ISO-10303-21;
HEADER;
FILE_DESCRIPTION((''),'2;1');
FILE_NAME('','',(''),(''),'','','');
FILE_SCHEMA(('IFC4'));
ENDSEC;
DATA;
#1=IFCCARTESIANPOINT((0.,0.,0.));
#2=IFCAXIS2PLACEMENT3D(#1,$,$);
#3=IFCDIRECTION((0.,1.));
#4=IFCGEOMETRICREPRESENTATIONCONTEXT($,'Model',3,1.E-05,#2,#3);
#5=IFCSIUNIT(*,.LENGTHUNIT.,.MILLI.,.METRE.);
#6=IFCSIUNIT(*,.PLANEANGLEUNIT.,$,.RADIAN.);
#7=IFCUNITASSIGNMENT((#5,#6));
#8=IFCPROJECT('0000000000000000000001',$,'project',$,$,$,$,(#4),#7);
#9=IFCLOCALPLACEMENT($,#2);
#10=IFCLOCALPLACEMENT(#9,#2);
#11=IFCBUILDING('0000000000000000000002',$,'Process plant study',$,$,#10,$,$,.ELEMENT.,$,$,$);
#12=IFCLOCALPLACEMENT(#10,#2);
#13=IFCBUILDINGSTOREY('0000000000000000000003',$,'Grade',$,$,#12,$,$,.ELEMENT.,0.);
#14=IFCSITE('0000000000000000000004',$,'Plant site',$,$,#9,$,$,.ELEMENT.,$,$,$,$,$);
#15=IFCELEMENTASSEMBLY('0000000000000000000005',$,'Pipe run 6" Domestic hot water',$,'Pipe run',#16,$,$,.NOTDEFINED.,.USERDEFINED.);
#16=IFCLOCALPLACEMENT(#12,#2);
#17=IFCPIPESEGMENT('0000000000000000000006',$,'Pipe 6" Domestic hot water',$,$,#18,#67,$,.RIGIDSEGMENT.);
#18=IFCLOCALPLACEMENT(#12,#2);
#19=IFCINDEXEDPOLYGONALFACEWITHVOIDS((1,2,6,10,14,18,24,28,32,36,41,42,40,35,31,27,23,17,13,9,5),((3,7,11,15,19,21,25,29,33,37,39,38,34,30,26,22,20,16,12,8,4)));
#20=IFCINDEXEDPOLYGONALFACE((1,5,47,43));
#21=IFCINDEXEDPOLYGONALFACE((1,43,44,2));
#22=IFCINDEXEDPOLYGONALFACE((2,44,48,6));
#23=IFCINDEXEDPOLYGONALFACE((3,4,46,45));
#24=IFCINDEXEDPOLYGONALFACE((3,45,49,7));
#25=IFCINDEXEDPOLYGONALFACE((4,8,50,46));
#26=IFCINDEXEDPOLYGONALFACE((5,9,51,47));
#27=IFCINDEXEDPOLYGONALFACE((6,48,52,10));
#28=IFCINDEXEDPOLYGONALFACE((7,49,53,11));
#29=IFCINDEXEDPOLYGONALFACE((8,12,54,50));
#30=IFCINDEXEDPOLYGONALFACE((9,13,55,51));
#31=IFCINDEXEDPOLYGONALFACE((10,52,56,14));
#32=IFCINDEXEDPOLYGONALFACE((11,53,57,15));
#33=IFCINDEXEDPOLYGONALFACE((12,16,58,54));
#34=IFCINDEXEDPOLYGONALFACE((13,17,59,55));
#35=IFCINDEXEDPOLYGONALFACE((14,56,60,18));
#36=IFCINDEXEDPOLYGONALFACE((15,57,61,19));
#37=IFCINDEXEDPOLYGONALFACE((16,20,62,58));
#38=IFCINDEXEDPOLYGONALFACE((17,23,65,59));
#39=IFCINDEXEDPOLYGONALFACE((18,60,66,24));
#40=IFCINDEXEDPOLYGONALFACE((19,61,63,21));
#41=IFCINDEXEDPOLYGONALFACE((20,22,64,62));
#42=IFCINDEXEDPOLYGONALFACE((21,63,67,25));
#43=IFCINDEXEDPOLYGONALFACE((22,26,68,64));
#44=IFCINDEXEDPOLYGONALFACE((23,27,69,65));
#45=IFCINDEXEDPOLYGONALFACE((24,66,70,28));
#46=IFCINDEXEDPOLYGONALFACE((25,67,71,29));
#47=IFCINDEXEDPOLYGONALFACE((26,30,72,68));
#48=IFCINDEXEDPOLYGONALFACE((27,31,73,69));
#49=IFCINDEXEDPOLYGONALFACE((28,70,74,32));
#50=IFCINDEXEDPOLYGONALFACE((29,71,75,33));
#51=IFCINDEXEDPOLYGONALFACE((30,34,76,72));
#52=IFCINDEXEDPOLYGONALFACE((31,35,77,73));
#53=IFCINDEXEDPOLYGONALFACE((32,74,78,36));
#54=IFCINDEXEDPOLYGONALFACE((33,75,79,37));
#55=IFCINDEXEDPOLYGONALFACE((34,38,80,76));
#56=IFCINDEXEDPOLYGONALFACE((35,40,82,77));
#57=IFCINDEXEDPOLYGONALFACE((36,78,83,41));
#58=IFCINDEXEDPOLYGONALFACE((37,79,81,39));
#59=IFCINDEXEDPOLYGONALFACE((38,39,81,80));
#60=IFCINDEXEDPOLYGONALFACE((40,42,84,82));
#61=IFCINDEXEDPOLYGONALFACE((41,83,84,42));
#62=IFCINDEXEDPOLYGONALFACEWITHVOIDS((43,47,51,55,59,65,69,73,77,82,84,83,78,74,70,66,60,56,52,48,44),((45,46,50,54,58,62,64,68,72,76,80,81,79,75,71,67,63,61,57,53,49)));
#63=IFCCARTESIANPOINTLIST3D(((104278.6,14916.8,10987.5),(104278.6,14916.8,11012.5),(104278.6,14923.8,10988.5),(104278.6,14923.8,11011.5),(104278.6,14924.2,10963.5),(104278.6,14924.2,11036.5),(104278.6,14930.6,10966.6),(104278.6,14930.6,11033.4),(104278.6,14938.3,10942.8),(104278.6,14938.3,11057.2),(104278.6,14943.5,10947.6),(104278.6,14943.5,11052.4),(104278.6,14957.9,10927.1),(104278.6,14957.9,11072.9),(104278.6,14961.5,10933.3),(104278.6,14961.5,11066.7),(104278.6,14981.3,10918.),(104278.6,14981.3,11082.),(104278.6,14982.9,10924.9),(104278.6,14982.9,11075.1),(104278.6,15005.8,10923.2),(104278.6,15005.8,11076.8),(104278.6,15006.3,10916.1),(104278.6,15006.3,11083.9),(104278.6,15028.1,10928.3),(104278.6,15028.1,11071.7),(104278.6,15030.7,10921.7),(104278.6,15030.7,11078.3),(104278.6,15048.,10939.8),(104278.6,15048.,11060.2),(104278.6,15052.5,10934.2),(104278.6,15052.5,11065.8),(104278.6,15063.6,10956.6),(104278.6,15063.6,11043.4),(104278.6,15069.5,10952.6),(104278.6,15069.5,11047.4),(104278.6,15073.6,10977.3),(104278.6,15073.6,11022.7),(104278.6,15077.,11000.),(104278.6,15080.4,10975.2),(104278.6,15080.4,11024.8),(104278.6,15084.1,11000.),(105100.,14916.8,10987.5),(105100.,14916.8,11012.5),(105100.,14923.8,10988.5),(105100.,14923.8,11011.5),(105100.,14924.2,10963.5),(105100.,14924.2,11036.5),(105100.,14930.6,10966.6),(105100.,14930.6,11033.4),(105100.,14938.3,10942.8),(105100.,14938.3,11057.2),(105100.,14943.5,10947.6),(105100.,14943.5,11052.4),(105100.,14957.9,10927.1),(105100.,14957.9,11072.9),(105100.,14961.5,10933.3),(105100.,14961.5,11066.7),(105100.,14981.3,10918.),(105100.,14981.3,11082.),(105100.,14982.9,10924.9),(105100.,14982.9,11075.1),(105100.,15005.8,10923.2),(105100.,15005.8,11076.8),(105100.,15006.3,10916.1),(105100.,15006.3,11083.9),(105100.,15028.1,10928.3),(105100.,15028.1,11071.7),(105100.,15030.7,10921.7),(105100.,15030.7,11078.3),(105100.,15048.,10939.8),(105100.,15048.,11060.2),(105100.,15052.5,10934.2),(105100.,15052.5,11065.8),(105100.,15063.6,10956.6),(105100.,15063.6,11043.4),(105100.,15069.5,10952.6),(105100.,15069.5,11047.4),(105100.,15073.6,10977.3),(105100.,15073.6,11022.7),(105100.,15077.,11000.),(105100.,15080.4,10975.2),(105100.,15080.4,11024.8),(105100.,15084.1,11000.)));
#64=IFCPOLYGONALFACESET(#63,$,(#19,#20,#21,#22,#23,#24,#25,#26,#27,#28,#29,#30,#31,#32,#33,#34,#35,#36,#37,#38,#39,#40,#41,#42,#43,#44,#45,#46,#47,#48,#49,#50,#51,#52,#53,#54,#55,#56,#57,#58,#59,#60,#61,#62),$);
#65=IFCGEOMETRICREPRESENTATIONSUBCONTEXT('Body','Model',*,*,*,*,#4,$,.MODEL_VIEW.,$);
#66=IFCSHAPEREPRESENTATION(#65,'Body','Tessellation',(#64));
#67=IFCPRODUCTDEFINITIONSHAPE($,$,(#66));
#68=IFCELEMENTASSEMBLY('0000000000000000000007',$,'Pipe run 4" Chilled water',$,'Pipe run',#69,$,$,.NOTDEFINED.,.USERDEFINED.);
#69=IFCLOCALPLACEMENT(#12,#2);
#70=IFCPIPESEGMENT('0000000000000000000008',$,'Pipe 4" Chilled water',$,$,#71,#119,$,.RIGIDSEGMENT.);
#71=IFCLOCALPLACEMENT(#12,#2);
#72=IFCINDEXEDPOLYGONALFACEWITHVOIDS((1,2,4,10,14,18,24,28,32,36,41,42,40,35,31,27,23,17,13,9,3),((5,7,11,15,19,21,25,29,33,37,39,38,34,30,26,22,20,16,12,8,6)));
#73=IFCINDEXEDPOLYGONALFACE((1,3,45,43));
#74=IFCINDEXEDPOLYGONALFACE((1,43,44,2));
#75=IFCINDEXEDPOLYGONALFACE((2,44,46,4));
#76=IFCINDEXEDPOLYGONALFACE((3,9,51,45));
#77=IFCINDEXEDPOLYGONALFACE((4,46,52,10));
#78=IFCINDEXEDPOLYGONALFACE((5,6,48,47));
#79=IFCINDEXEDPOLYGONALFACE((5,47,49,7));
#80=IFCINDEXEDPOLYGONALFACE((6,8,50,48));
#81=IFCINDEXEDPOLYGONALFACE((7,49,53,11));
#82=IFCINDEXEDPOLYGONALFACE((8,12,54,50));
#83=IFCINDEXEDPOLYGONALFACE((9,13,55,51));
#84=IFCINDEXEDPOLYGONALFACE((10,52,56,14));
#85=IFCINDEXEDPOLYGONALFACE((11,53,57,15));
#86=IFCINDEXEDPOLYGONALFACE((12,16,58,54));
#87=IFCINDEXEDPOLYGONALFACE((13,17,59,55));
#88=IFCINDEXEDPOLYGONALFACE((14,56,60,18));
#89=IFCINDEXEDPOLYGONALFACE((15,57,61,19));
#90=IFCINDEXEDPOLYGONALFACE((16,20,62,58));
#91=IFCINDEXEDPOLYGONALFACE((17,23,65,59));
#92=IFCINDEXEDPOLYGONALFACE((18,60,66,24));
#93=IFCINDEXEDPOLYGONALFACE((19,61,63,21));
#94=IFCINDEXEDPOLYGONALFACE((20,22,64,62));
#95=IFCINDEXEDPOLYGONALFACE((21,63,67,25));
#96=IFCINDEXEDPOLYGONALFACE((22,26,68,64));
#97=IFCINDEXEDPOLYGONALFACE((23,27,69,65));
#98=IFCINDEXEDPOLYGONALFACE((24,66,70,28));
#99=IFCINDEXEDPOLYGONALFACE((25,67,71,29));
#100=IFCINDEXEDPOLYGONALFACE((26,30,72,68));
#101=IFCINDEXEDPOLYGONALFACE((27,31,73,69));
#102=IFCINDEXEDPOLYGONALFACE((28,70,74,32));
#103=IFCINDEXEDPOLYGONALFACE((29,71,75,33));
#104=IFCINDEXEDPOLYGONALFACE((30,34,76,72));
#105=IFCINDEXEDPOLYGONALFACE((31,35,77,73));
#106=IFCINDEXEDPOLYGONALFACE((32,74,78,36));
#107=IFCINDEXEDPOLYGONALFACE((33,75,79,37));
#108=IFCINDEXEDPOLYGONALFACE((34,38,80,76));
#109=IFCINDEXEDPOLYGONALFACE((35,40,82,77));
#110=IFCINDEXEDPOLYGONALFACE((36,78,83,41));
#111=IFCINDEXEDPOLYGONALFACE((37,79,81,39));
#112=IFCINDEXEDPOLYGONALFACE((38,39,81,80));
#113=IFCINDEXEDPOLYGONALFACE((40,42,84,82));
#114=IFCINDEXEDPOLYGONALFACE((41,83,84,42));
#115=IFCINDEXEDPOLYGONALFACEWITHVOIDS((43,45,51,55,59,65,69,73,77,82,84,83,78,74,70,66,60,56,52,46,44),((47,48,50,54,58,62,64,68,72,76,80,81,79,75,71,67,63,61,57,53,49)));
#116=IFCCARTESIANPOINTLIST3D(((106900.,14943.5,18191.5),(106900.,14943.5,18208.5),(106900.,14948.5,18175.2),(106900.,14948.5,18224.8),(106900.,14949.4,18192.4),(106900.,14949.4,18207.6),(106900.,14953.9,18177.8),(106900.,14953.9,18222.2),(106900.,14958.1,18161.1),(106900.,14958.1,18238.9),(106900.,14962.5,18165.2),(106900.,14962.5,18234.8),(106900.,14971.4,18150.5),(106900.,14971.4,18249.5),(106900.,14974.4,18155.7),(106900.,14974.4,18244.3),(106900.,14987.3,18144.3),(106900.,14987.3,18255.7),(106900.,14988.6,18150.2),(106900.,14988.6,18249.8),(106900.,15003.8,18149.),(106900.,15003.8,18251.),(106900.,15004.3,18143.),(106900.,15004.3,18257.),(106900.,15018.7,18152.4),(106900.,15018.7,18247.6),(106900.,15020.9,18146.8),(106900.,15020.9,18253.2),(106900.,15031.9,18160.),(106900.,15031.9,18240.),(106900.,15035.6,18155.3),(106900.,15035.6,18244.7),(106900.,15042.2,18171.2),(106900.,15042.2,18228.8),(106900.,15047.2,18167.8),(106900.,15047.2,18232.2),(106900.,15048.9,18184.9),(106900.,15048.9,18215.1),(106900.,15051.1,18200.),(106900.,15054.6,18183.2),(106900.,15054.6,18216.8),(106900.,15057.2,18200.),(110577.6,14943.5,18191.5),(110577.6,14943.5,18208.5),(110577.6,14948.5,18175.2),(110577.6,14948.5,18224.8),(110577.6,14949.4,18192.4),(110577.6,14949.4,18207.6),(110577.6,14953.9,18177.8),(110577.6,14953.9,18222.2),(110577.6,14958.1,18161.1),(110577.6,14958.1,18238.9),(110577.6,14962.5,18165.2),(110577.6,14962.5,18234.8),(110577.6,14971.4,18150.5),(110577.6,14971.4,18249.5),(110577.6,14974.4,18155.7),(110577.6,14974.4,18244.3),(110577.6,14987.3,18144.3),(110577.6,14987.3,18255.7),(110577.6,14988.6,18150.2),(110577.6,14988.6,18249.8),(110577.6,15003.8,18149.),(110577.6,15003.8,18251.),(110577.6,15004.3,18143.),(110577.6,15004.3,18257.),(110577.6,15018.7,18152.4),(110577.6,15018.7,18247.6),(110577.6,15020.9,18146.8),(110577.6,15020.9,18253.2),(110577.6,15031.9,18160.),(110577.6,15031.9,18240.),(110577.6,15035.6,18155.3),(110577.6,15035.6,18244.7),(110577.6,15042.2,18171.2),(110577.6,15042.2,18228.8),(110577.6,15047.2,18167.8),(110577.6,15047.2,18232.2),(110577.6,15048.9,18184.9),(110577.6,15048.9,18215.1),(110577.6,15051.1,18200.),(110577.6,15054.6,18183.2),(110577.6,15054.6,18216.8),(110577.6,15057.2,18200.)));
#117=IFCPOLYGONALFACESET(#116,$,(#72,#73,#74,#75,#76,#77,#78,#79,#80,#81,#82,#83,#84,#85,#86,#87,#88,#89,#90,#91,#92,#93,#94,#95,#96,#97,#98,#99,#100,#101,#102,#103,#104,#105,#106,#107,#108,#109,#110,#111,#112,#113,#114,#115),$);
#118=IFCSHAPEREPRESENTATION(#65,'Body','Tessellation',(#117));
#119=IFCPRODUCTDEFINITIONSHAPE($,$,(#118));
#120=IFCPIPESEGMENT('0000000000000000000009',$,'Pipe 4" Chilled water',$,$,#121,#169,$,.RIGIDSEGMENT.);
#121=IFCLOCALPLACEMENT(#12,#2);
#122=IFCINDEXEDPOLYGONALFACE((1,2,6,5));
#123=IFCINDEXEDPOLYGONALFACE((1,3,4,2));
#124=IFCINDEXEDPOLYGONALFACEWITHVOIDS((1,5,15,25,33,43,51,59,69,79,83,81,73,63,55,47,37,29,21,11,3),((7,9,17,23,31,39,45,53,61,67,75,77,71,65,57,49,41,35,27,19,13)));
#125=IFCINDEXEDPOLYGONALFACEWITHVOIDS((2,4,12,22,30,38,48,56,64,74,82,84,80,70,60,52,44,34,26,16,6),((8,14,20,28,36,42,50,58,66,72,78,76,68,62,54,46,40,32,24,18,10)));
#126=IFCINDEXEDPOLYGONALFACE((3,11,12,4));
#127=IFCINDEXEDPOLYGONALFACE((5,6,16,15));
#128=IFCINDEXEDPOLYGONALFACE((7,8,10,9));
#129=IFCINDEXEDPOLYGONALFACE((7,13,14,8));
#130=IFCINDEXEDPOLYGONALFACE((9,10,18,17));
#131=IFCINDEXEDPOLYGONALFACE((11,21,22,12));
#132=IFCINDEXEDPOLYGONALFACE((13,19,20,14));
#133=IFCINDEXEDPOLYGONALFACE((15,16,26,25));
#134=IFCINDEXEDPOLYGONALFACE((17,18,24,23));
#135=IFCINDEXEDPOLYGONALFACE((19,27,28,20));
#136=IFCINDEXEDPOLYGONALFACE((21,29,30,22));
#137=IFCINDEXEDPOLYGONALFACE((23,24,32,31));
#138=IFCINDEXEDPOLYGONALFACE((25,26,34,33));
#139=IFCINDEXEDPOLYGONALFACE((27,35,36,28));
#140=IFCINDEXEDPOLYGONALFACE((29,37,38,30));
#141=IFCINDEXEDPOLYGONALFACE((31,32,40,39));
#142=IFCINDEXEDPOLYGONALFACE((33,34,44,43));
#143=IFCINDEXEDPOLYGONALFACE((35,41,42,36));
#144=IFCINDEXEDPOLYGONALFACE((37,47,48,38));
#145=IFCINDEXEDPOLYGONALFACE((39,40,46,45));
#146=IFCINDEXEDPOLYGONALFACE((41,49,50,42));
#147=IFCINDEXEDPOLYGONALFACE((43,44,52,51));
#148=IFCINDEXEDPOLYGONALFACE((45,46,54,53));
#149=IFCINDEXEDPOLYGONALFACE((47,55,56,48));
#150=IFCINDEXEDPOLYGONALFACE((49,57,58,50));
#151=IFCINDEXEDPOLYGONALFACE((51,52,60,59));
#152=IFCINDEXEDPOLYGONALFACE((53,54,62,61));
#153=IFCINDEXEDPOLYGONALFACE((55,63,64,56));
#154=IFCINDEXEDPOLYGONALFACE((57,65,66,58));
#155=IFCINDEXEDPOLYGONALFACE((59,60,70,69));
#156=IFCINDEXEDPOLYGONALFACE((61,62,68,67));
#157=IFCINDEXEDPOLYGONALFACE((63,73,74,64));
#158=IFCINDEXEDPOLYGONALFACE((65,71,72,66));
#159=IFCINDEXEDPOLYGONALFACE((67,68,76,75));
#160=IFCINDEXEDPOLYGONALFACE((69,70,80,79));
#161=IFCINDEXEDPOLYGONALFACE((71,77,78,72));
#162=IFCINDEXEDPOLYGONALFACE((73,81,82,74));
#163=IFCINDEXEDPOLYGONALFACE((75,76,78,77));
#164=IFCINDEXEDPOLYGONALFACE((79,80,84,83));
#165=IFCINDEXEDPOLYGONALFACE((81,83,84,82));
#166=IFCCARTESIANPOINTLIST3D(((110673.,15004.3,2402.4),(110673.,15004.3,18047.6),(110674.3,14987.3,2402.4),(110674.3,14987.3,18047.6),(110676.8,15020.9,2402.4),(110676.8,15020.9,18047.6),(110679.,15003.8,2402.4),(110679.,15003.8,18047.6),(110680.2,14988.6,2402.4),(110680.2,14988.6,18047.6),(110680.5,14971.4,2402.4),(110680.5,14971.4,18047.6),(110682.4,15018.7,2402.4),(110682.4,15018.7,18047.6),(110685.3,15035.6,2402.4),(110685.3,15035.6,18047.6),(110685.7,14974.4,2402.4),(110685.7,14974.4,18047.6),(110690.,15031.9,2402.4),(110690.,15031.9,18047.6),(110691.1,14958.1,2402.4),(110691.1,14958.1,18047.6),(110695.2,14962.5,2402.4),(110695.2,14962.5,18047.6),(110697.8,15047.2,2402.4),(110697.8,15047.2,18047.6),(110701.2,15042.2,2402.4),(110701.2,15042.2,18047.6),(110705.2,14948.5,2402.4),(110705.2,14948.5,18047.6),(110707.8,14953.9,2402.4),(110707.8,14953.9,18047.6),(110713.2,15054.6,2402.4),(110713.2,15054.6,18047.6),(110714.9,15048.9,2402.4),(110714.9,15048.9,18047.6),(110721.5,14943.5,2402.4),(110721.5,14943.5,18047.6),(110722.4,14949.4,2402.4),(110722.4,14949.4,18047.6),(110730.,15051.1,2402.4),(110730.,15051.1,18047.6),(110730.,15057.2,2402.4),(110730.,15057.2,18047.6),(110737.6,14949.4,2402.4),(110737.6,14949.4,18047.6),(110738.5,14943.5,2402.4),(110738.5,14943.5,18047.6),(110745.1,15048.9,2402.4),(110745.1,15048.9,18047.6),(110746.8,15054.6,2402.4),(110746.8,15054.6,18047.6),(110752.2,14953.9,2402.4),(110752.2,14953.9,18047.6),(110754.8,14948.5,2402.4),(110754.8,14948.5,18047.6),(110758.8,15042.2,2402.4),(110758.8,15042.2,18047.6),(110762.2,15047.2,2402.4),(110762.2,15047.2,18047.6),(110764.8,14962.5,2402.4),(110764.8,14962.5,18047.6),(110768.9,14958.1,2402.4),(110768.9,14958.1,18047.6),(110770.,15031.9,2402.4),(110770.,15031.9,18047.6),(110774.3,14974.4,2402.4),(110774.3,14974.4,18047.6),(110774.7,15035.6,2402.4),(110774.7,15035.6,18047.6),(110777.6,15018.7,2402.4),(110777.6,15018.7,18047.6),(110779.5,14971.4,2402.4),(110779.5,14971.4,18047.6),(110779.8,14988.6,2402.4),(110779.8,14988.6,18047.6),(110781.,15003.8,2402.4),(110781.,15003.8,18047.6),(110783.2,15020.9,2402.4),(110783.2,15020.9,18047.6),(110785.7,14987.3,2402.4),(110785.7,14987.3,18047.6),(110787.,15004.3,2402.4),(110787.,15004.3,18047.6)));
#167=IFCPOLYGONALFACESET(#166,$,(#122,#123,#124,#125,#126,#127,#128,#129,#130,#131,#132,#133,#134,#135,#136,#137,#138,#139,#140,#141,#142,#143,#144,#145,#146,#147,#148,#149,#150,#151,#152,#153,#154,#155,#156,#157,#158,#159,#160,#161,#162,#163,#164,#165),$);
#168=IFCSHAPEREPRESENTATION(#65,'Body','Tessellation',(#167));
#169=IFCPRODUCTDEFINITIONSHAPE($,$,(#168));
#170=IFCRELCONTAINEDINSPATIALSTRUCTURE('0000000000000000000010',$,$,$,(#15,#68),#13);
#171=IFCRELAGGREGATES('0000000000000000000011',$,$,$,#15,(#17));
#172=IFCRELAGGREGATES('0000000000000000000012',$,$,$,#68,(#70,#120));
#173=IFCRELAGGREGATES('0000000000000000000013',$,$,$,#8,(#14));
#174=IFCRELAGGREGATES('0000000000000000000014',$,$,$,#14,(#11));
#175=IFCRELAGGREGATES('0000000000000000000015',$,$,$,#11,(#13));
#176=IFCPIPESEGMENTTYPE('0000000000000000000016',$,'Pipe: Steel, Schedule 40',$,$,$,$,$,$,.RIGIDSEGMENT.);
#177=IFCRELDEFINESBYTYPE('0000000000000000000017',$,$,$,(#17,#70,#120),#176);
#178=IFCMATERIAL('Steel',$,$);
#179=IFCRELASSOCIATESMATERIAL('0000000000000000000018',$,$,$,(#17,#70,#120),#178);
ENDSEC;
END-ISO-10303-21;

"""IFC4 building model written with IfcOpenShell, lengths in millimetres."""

from ifc_helpers import new_model, si_unit, direction, frame, origin, origin_with_axes, origin_2d, place, context, subcontext, project, spatial, hollow_circle, extrude, material, type_object, element, aggregate, save


model = new_model("IFC4")

# Units and contexts
model_context = context("Model", 3, precision=1e-05, world=origin(), true_north=direction((0.0, 1.0)))
body_context = subcontext(model_context, "Body", "Model", "MODEL_VIEW")
ifc_project = project(units=[si_unit("LENGTHUNIT", "METRE", prefix="MILLI"), si_unit("PLANEANGLEUNIT", "RADIAN")], contexts=[model_context])

# Site, building, storey
site_placement = place(None, origin())
site = spatial("IfcSite", under=ifc_project, at=site_placement, Name="Plant site", CompositionType="ELEMENT")
building_placement = place(site_placement, origin())
building = spatial("IfcBuilding", under=site, at=building_placement, Name="Process plant study", CompositionType="ELEMENT")
storey_placement = place(building_placement, origin())
storey = spatial("IfcBuildingStorey", under=building, at=storey_placement, Name="Grade", CompositionType="ELEMENT", Elevation=0.0)

# Element assembly, pipe segment
assembly_1_placement = place(storey_placement, origin_with_axes())
assembly_1 = element("IfcElementAssembly", 1, at=assembly_1_placement, inside=storey, Name="Pipe run 6\" Domestic hot water", ObjectType="Pipe run", AssemblyPlace="NOTDEFINED", PredefinedType="USERDEFINED")
ifc_material = material(Name="Steel")
pipe_segment_type = type_object("IfcPipeSegmentType", Name="Pipe: Steel, Schedule 40", PredefinedType="RIGIDSEGMENT")
pipe_segment_1_placement = place(storey_placement, origin_with_axes())
pipe_segment_1 = element("IfcPipeSegment", 2, at=pipe_segment_1_placement, type_object=pipe_segment_type, material=ifc_material, Name="Pipe 6\" Domestic hot water", PredefinedType="RIGIDSEGMENT", context=body_context, shape_type="SweptSolid", body=[
    extrude(hollow_circle(Radius=84.1, WallThickness=7.1, at=origin_2d()), frame((104278.6, 15000.0, 11000.0), z_axis=(1.0, 0.0, 0.0), x_axis=(0.0, 1.0, 0.0)), (0.0, 0.0, 1.0), 821.4),
])

# Element assembly, pipe segments
assembly_2_placement = place(storey_placement, origin_with_axes())
assembly_2 = element("IfcElementAssembly", 3, at=assembly_2_placement, inside=storey, Name="Pipe run 4\" Chilled water", ObjectType="Pipe run", AssemblyPlace="NOTDEFINED", PredefinedType="USERDEFINED")
pipe_segment_2_placement = place(storey_placement, origin_with_axes())
pipe_segment_2 = element("IfcPipeSegment", 4, at=pipe_segment_2_placement, type_object=pipe_segment_type, material=ifc_material, Name="Pipe 4\" Chilled water", PredefinedType="RIGIDSEGMENT", context=body_context, shape_type="SweptSolid", body=[
    extrude(hollow_circle(Radius=57.1, WallThickness=6.0, at=origin_2d()), frame((106900.0, 15000.0, 18200.0), z_axis=(1.0, 0.0, 0.0), x_axis=(0.0, 1.0, 0.0)), (0.0, 0.0, 1.0), 3677.6),
])
pipe_segment_3_placement = place(storey_placement, origin_with_axes())
pipe_segment_3 = element("IfcPipeSegment", 5, at=pipe_segment_3_placement, type_object=pipe_segment_type, material=ifc_material, Name="Pipe 4\" Chilled water", PredefinedType="RIGIDSEGMENT", context=body_context, shape_type="SweptSolid", body=[
    extrude(hollow_circle(Radius=57.1, WallThickness=6.0, at=origin_2d()), frame((110730.0, 15000.0, 18047.6), z_axis=(0.0, 0.0, -1.0), x_axis=(0.0, 1.0, 0.0)), (0.0, 0.0, 1.0), 15645.2),
])

aggregate(assembly_1, [pipe_segment_1])
aggregate(assembly_2, [pipe_segment_2, pipe_segment_3])

save(model, "model.ifc")
